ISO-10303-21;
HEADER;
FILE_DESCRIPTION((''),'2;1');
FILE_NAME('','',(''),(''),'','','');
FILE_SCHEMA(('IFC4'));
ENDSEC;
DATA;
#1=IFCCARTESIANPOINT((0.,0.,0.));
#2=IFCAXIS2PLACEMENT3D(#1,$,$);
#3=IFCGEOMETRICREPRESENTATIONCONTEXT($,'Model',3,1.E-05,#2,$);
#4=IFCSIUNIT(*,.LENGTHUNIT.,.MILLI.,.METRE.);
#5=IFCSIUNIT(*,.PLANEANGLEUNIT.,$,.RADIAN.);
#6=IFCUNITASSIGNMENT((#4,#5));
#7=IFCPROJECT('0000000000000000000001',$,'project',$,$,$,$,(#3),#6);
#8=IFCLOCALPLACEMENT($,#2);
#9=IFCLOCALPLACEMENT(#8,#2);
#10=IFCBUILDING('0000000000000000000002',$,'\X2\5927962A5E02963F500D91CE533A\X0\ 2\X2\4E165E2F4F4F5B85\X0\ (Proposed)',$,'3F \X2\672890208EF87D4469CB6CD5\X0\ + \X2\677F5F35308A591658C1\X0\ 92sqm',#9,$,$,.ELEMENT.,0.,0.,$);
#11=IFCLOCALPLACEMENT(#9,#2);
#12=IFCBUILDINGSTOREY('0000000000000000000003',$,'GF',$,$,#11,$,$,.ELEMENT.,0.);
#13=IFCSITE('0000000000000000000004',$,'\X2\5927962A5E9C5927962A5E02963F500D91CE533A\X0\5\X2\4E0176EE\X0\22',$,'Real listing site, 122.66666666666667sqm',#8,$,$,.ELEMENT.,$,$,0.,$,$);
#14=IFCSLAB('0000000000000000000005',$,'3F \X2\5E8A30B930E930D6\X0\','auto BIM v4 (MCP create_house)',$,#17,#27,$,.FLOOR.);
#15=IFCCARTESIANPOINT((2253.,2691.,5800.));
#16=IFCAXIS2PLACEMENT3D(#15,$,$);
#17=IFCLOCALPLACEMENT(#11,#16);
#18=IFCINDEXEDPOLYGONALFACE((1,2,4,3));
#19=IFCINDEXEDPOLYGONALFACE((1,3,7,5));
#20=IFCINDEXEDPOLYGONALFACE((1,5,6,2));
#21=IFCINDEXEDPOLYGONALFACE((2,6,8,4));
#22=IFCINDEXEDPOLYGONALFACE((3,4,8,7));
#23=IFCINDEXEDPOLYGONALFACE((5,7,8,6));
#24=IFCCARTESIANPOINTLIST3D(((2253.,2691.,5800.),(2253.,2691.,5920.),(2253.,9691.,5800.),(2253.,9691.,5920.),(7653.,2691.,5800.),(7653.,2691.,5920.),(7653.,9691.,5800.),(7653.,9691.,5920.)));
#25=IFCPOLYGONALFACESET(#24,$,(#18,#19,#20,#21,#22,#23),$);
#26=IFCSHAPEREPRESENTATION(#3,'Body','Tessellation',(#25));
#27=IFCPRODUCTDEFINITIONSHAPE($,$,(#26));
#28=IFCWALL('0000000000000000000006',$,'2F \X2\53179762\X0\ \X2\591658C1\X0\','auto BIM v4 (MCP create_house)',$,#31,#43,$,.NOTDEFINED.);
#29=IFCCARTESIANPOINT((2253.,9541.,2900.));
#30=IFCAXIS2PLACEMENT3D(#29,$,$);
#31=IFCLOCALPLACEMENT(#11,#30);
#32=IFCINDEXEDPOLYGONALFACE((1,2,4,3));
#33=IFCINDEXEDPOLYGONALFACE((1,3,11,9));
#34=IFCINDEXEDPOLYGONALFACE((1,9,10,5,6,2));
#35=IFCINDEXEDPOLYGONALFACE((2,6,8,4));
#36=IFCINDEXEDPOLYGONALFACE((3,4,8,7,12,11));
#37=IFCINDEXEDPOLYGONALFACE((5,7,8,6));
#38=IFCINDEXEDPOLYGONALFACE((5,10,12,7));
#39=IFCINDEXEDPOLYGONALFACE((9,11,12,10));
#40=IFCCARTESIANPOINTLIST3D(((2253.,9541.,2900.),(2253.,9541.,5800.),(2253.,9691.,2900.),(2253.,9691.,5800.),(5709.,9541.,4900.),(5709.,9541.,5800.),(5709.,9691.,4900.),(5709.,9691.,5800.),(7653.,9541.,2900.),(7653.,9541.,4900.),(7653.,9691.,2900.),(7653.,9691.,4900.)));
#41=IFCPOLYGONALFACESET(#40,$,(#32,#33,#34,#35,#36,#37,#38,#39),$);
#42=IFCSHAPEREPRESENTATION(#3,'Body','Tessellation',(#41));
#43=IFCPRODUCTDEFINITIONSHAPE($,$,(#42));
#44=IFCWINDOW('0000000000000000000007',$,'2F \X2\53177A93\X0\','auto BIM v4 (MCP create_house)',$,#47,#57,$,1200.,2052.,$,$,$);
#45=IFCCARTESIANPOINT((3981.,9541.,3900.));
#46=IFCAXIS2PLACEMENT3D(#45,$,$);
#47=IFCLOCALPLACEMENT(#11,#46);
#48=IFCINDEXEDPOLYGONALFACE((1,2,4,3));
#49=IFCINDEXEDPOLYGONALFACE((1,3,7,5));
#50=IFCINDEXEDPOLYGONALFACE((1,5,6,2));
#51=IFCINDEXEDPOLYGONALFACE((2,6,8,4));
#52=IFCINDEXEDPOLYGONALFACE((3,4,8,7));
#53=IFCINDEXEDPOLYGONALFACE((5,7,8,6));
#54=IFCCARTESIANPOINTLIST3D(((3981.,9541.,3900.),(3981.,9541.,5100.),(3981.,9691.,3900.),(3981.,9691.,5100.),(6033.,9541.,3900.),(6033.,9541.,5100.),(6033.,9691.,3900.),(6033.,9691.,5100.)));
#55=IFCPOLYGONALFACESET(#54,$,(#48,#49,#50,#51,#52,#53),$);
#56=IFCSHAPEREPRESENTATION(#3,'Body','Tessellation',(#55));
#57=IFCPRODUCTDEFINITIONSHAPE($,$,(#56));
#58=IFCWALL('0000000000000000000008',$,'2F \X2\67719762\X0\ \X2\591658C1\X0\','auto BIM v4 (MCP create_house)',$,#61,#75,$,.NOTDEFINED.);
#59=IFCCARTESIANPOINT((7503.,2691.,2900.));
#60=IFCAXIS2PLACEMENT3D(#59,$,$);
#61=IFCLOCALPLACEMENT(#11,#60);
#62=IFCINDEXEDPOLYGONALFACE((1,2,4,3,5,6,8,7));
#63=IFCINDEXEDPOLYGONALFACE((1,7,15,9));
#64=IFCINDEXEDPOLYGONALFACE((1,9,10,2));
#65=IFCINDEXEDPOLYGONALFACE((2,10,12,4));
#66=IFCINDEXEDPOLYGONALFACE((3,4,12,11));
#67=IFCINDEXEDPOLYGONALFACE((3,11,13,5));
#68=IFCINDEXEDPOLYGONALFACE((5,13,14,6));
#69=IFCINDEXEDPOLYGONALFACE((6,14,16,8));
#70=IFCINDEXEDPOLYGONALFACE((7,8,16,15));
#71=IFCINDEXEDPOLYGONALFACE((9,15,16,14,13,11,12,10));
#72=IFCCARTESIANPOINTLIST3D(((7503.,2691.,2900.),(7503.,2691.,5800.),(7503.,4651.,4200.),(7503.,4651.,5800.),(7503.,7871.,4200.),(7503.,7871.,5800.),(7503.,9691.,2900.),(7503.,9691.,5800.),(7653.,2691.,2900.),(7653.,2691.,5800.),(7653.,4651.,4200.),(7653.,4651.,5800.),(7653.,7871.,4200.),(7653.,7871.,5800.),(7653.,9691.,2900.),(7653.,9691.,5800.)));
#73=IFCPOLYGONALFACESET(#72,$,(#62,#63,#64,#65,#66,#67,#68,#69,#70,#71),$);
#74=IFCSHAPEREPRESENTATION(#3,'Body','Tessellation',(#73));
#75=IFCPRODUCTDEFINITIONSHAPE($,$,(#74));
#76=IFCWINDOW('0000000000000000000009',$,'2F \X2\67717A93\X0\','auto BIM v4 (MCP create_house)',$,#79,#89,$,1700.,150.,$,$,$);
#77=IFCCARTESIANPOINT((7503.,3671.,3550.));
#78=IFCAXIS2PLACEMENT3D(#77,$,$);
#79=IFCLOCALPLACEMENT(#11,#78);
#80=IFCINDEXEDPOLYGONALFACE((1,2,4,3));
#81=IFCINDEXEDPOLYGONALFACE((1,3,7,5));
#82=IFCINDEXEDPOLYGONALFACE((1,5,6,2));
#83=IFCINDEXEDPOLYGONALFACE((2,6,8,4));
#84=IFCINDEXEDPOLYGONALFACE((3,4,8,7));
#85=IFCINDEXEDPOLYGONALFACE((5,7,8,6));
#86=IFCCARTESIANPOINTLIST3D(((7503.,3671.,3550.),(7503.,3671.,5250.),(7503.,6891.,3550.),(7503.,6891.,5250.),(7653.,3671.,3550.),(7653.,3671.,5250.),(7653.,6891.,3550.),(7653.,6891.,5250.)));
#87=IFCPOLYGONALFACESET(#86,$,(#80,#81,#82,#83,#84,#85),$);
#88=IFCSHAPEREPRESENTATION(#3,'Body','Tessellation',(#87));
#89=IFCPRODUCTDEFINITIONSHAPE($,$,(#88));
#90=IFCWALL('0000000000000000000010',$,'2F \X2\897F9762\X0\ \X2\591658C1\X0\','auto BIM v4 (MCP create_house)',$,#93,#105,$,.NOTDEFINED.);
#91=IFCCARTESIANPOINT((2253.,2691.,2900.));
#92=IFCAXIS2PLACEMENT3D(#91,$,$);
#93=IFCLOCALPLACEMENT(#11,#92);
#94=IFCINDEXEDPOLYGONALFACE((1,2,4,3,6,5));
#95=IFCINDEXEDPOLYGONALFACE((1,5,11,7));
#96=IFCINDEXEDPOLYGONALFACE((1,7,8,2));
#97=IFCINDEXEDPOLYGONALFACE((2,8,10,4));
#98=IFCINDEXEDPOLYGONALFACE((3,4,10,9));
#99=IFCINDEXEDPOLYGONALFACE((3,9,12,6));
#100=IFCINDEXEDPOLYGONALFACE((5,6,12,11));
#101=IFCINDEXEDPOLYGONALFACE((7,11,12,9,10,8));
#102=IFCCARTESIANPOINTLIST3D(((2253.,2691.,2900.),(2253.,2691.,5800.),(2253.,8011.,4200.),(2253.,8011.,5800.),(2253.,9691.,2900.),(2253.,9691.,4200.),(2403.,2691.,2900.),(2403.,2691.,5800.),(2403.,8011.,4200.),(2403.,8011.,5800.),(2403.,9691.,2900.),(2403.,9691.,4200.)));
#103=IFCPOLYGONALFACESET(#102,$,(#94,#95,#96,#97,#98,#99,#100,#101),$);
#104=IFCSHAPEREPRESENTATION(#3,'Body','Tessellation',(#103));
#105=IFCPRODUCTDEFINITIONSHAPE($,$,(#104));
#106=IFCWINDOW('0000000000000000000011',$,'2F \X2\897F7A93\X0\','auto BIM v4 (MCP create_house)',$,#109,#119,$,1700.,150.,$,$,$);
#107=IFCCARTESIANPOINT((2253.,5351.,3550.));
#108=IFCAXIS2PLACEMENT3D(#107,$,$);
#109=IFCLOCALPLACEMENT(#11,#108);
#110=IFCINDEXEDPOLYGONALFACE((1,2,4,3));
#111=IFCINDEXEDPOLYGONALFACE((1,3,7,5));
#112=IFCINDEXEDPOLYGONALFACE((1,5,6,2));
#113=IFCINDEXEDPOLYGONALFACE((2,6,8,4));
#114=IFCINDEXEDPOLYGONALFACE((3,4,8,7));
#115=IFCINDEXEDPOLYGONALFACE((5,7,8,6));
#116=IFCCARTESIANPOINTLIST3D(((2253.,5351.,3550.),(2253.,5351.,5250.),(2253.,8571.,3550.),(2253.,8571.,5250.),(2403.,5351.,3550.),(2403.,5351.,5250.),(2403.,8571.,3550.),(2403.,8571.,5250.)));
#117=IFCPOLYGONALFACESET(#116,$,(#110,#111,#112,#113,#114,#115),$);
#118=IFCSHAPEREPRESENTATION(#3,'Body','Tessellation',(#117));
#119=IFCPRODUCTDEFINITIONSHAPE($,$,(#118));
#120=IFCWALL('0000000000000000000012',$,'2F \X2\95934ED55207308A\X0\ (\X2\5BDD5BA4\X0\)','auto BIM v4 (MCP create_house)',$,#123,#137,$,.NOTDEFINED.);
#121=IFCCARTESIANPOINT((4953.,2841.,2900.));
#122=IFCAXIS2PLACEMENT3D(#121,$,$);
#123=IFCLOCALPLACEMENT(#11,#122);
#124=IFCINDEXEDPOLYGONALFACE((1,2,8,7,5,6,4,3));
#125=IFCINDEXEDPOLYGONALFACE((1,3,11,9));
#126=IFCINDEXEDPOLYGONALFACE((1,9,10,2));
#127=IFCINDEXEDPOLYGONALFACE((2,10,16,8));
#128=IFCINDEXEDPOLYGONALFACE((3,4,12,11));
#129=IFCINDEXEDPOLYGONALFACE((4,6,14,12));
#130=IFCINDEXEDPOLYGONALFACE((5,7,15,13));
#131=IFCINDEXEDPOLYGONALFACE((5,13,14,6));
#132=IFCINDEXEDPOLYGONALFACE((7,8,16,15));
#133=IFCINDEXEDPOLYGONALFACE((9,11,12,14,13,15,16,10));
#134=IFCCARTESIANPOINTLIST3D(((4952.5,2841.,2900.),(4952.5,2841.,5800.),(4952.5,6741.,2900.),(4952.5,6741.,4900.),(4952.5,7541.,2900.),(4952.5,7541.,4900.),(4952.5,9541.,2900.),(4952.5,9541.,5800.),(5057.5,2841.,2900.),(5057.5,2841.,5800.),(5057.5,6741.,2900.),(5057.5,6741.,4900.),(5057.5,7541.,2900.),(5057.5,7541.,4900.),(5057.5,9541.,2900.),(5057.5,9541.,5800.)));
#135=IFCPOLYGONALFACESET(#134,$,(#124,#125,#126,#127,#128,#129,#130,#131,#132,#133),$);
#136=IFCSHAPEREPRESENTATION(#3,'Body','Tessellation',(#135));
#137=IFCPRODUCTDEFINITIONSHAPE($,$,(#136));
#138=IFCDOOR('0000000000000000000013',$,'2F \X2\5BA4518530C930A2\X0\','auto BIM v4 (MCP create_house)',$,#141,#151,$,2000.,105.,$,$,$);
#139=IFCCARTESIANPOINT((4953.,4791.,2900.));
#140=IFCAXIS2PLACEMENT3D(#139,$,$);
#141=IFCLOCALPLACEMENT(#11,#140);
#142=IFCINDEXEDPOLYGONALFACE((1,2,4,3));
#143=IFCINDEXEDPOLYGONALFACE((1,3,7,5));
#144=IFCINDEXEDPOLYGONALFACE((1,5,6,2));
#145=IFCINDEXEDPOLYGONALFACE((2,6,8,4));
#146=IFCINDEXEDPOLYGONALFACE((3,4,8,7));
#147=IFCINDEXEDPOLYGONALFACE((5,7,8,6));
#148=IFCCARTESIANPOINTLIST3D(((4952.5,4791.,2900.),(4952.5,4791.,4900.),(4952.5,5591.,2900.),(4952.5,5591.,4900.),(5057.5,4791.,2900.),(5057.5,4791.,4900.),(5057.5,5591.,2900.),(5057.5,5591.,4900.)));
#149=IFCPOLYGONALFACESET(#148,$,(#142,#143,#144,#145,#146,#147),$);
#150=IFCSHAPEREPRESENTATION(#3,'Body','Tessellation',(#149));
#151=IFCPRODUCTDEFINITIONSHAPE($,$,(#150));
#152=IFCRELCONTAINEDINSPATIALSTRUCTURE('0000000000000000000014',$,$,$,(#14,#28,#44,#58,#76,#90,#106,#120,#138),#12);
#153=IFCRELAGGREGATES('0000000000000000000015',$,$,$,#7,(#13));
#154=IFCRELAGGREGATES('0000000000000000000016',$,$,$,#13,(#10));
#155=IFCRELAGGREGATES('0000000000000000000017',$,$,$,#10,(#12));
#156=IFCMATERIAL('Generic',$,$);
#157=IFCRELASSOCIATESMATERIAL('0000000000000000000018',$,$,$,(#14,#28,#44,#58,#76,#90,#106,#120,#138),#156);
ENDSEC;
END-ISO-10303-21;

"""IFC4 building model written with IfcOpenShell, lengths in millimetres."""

from ifc_helpers import new_model, si_unit, frame, frame_2d, origin, place, context, project, spatial, rectangle, extrude, material, element, fill, save


model = new_model("IFC4")

# Units and contexts
model_context = context("Model", 3, precision=1e-05, world=origin())
ifc_project = project(units=[si_unit("LENGTHUNIT", "METRE", prefix="MILLI"), si_unit("PLANEANGLEUNIT", "RADIAN")], contexts=[model_context])

# Site, building, storey
site_placement = place(None, origin())
site = spatial("IfcSite", under=ifc_project, at=site_placement, Name="大阪府大阪市阿倍野区5丁目22", ObjectType="Real listing site, 122.66666666666667sqm", CompositionType="ELEMENT", RefElevation=0.0)
building_placement = place(site_placement, origin())
building = spatial("IfcBuilding", under=site, at=building_placement, Name="大阪市阿倍野区 2世帯住宅 (Proposed)", ObjectType="3F 木造軸組構法 + 板張り外壁 92sqm", CompositionType="ELEMENT", ElevationOfRefHeight=0.0, ElevationOfTerrain=0.0)
storey_placement = place(building_placement, origin())
storey = spatial("IfcBuildingStorey", under=building, at=storey_placement, Name="GF", CompositionType="ELEMENT", Elevation=0.0)

# Slab
ifc_material = material(Name="Generic")
slab_placement = place(storey_placement, frame((2253.0, 2691.0, 5800.0)))
element("IfcSlab", 1, at=slab_placement, inside=storey, material=ifc_material, Name="3F 床スラブ", Description="auto BIM v4 (MCP create_house)", PredefinedType="FLOOR", context=model_context, shape_type="SweptSolid", body=[
    extrude(rectangle(XDim=5400.0, YDim=7000.0, at=frame_2d((2700.0, 3500.0))), frame((2253.0, 2691.0, 5800.0)), (0.0, 0.0, 1.0), 120.0),
])

# Walls, openings, windows
wall_1_placement = place(storey_placement, frame((2253.0, 9541.0, 2900.0)))
wall_1 = element("IfcWall", 2, at=wall_1_placement, inside=storey, material=ifc_material, Name="2F 北面 外壁", Description="auto BIM v4 (MCP create_house)", PredefinedType="NOTDEFINED", context=model_context, shape_type="SweptSolid", body=[
    extrude(rectangle(XDim=5400.0, YDim=150.0, at=frame_2d((2700.0, 75.0))), frame((2253.0, 9541.0, 2900.0)), (0.0, 0.0, 1.0), 2900.0),
])
opening_1_placement = place(storey_placement, frame((3981.0, 9541.0, 3900.0)))
opening_1 = element("IfcOpeningElement", 3, at=opening_1_placement, cuts=wall_1, PredefinedType="NOTDEFINED", context=model_context, shape_type="SweptSolid", body=[
    extrude(rectangle(XDim=2052.0, YDim=150.0, at=frame_2d((1026.0, 75.0))), frame((3981.0, 9541.0, 3900.0)), (0.0, 0.0, 1.0), 1200.0),
])
window_1_placement = place(storey_placement, frame((3981.0, 9541.0, 3900.0)))
window_1 = element("IfcWindow", 4, at=window_1_placement, inside=storey, material=ifc_material, Name="2F 北窓", Description="auto BIM v4 (MCP create_house)", OverallHeight=1200.0, OverallWidth=2052.0, context=model_context, shape_type="SweptSolid", body=[
    extrude(rectangle(XDim=2052.0, YDim=150.0, at=frame_2d((1026.0, 75.0))), frame((3981.0, 9541.0, 3900.0)), (0.0, 0.0, 1.0), 1200.0),
])
fill(opening_1, window_1)
wall_2_placement = place(storey_placement, frame((7503.0, 2691.0, 2900.0)))
wall_2 = element("IfcWall", 5, at=wall_2_placement, inside=storey, material=ifc_material, Name="2F 東面 外壁", Description="auto BIM v4 (MCP create_house)", PredefinedType="NOTDEFINED", context=model_context, shape_type="SweptSolid", body=[
    extrude(rectangle(XDim=150.0, YDim=7000.0, at=frame_2d((75.0, 3500.0))), frame((7503.0, 2691.0, 2900.0)), (0.0, 0.0, 1.0), 2900.0),
])
opening_2_placement = place(storey_placement, frame((7503.0, 3671.0, 3550.0)))
opening_2 = element("IfcOpeningElement", 6, at=opening_2_placement, cuts=wall_2, PredefinedType="NOTDEFINED", context=model_context, shape_type="SweptSolid", body=[
    extrude(rectangle(XDim=150.0, YDim=3220.0, at=frame_2d((75.0, 1610.0))), frame((7503.0, 3671.0, 3550.0)), (0.0, 0.0, 1.0), 1700.0),
])
window_2_placement = place(storey_placement, frame((7503.0, 3671.0, 3550.0)))
window_2 = element("IfcWindow", 7, at=window_2_placement, inside=storey, material=ifc_material, Name="2F 東窓", Description="auto BIM v4 (MCP create_house)", OverallHeight=1700.0, OverallWidth=150.0, context=model_context, shape_type="SweptSolid", body=[
    extrude(rectangle(XDim=150.0, YDim=3220.0, at=frame_2d((75.0, 1610.0))), frame((7503.0, 3671.0, 3550.0)), (0.0, 0.0, 1.0), 1700.0),
])
fill(opening_2, window_2)
wall_3_placement = place(storey_placement, frame((2253.0, 2691.0, 2900.0)))
wall_3 = element("IfcWall", 8, at=wall_3_placement, inside=storey, material=ifc_material, Name="2F 西面 外壁", Description="auto BIM v4 (MCP create_house)", PredefinedType="NOTDEFINED", context=model_context, shape_type="SweptSolid", body=[
    extrude(rectangle(XDim=150.0, YDim=7000.0, at=frame_2d((75.0, 3500.0))), frame((2253.0, 2691.0, 2900.0)), (0.0, 0.0, 1.0), 2900.0),
])
opening_3_placement = place(storey_placement, frame((2253.0, 5351.0, 3550.0)))
opening_3 = element("IfcOpeningElement", 9, at=opening_3_placement, cuts=wall_3, PredefinedType="NOTDEFINED", context=model_context, shape_type="SweptSolid", body=[
    extrude(rectangle(XDim=150.0, YDim=3220.0, at=frame_2d((75.0, 1610.0))), frame((2253.0, 5351.0, 3550.0)), (0.0, 0.0, 1.0), 1700.0),
])
window_3_placement = place(storey_placement, frame((2253.0, 5351.0, 3550.0)))
window_3 = element("IfcWindow", 10, at=window_3_placement, inside=storey, material=ifc_material, Name="2F 西窓", Description="auto BIM v4 (MCP create_house)", OverallHeight=1700.0, OverallWidth=150.0, context=model_context, shape_type="SweptSolid", body=[
    extrude(rectangle(XDim=150.0, YDim=3220.0, at=frame_2d((75.0, 1610.0))), frame((2253.0, 5351.0, 3550.0)), (0.0, 0.0, 1.0), 1700.0),
])
fill(opening_3, window_3)

# Wall, opening, door
wall_4_placement = place(storey_placement, frame((4953.0, 2841.0, 2900.0)))
wall_4 = element("IfcWall", 11, at=wall_4_placement, inside=storey, material=ifc_material, Name="2F 間仕切り (寝室)", Description="auto BIM v4 (MCP create_house)", PredefinedType="NOTDEFINED", context=model_context, shape_type="SweptSolid", body=[
    extrude(rectangle(XDim=105.0, YDim=6700.0, at=frame_2d((52.0, 3350.0))), frame((4953.0, 2841.0, 2900.0)), (0.0, 0.0, 1.0), 2900.0),
])
opening_4_placement = place(storey_placement, frame((4953.0, 4791.0, 2900.0)))
opening_4 = element("IfcOpeningElement", 12, at=opening_4_placement, cuts=wall_4, PredefinedType="NOTDEFINED", context=model_context, shape_type="SweptSolid", body=[
    extrude(rectangle(XDim=105.0, YDim=800.0, at=frame_2d((52.0, 400.0))), frame((4953.0, 4791.0, 2900.0)), (0.0, 0.0, 1.0), 2000.0),
])
door_1_placement = place(storey_placement, frame((4953.0, 4791.0, 2900.0)))
door_1 = element("IfcDoor", 13, at=door_1_placement, inside=storey, material=ifc_material, Name="2F 室内ドア", Description="auto BIM v4 (MCP create_house)", OverallHeight=2000.0, OverallWidth=105.0, context=model_context, shape_type="SweptSolid", body=[
    extrude(rectangle(XDim=105.0, YDim=800.0, at=frame_2d((52.0, 400.0))), frame((4953.0, 4791.0, 2900.0)), (0.0, 0.0, 1.0), 2000.0),
])
fill(opening_4, door_1)

save(model, "model.ifc")
